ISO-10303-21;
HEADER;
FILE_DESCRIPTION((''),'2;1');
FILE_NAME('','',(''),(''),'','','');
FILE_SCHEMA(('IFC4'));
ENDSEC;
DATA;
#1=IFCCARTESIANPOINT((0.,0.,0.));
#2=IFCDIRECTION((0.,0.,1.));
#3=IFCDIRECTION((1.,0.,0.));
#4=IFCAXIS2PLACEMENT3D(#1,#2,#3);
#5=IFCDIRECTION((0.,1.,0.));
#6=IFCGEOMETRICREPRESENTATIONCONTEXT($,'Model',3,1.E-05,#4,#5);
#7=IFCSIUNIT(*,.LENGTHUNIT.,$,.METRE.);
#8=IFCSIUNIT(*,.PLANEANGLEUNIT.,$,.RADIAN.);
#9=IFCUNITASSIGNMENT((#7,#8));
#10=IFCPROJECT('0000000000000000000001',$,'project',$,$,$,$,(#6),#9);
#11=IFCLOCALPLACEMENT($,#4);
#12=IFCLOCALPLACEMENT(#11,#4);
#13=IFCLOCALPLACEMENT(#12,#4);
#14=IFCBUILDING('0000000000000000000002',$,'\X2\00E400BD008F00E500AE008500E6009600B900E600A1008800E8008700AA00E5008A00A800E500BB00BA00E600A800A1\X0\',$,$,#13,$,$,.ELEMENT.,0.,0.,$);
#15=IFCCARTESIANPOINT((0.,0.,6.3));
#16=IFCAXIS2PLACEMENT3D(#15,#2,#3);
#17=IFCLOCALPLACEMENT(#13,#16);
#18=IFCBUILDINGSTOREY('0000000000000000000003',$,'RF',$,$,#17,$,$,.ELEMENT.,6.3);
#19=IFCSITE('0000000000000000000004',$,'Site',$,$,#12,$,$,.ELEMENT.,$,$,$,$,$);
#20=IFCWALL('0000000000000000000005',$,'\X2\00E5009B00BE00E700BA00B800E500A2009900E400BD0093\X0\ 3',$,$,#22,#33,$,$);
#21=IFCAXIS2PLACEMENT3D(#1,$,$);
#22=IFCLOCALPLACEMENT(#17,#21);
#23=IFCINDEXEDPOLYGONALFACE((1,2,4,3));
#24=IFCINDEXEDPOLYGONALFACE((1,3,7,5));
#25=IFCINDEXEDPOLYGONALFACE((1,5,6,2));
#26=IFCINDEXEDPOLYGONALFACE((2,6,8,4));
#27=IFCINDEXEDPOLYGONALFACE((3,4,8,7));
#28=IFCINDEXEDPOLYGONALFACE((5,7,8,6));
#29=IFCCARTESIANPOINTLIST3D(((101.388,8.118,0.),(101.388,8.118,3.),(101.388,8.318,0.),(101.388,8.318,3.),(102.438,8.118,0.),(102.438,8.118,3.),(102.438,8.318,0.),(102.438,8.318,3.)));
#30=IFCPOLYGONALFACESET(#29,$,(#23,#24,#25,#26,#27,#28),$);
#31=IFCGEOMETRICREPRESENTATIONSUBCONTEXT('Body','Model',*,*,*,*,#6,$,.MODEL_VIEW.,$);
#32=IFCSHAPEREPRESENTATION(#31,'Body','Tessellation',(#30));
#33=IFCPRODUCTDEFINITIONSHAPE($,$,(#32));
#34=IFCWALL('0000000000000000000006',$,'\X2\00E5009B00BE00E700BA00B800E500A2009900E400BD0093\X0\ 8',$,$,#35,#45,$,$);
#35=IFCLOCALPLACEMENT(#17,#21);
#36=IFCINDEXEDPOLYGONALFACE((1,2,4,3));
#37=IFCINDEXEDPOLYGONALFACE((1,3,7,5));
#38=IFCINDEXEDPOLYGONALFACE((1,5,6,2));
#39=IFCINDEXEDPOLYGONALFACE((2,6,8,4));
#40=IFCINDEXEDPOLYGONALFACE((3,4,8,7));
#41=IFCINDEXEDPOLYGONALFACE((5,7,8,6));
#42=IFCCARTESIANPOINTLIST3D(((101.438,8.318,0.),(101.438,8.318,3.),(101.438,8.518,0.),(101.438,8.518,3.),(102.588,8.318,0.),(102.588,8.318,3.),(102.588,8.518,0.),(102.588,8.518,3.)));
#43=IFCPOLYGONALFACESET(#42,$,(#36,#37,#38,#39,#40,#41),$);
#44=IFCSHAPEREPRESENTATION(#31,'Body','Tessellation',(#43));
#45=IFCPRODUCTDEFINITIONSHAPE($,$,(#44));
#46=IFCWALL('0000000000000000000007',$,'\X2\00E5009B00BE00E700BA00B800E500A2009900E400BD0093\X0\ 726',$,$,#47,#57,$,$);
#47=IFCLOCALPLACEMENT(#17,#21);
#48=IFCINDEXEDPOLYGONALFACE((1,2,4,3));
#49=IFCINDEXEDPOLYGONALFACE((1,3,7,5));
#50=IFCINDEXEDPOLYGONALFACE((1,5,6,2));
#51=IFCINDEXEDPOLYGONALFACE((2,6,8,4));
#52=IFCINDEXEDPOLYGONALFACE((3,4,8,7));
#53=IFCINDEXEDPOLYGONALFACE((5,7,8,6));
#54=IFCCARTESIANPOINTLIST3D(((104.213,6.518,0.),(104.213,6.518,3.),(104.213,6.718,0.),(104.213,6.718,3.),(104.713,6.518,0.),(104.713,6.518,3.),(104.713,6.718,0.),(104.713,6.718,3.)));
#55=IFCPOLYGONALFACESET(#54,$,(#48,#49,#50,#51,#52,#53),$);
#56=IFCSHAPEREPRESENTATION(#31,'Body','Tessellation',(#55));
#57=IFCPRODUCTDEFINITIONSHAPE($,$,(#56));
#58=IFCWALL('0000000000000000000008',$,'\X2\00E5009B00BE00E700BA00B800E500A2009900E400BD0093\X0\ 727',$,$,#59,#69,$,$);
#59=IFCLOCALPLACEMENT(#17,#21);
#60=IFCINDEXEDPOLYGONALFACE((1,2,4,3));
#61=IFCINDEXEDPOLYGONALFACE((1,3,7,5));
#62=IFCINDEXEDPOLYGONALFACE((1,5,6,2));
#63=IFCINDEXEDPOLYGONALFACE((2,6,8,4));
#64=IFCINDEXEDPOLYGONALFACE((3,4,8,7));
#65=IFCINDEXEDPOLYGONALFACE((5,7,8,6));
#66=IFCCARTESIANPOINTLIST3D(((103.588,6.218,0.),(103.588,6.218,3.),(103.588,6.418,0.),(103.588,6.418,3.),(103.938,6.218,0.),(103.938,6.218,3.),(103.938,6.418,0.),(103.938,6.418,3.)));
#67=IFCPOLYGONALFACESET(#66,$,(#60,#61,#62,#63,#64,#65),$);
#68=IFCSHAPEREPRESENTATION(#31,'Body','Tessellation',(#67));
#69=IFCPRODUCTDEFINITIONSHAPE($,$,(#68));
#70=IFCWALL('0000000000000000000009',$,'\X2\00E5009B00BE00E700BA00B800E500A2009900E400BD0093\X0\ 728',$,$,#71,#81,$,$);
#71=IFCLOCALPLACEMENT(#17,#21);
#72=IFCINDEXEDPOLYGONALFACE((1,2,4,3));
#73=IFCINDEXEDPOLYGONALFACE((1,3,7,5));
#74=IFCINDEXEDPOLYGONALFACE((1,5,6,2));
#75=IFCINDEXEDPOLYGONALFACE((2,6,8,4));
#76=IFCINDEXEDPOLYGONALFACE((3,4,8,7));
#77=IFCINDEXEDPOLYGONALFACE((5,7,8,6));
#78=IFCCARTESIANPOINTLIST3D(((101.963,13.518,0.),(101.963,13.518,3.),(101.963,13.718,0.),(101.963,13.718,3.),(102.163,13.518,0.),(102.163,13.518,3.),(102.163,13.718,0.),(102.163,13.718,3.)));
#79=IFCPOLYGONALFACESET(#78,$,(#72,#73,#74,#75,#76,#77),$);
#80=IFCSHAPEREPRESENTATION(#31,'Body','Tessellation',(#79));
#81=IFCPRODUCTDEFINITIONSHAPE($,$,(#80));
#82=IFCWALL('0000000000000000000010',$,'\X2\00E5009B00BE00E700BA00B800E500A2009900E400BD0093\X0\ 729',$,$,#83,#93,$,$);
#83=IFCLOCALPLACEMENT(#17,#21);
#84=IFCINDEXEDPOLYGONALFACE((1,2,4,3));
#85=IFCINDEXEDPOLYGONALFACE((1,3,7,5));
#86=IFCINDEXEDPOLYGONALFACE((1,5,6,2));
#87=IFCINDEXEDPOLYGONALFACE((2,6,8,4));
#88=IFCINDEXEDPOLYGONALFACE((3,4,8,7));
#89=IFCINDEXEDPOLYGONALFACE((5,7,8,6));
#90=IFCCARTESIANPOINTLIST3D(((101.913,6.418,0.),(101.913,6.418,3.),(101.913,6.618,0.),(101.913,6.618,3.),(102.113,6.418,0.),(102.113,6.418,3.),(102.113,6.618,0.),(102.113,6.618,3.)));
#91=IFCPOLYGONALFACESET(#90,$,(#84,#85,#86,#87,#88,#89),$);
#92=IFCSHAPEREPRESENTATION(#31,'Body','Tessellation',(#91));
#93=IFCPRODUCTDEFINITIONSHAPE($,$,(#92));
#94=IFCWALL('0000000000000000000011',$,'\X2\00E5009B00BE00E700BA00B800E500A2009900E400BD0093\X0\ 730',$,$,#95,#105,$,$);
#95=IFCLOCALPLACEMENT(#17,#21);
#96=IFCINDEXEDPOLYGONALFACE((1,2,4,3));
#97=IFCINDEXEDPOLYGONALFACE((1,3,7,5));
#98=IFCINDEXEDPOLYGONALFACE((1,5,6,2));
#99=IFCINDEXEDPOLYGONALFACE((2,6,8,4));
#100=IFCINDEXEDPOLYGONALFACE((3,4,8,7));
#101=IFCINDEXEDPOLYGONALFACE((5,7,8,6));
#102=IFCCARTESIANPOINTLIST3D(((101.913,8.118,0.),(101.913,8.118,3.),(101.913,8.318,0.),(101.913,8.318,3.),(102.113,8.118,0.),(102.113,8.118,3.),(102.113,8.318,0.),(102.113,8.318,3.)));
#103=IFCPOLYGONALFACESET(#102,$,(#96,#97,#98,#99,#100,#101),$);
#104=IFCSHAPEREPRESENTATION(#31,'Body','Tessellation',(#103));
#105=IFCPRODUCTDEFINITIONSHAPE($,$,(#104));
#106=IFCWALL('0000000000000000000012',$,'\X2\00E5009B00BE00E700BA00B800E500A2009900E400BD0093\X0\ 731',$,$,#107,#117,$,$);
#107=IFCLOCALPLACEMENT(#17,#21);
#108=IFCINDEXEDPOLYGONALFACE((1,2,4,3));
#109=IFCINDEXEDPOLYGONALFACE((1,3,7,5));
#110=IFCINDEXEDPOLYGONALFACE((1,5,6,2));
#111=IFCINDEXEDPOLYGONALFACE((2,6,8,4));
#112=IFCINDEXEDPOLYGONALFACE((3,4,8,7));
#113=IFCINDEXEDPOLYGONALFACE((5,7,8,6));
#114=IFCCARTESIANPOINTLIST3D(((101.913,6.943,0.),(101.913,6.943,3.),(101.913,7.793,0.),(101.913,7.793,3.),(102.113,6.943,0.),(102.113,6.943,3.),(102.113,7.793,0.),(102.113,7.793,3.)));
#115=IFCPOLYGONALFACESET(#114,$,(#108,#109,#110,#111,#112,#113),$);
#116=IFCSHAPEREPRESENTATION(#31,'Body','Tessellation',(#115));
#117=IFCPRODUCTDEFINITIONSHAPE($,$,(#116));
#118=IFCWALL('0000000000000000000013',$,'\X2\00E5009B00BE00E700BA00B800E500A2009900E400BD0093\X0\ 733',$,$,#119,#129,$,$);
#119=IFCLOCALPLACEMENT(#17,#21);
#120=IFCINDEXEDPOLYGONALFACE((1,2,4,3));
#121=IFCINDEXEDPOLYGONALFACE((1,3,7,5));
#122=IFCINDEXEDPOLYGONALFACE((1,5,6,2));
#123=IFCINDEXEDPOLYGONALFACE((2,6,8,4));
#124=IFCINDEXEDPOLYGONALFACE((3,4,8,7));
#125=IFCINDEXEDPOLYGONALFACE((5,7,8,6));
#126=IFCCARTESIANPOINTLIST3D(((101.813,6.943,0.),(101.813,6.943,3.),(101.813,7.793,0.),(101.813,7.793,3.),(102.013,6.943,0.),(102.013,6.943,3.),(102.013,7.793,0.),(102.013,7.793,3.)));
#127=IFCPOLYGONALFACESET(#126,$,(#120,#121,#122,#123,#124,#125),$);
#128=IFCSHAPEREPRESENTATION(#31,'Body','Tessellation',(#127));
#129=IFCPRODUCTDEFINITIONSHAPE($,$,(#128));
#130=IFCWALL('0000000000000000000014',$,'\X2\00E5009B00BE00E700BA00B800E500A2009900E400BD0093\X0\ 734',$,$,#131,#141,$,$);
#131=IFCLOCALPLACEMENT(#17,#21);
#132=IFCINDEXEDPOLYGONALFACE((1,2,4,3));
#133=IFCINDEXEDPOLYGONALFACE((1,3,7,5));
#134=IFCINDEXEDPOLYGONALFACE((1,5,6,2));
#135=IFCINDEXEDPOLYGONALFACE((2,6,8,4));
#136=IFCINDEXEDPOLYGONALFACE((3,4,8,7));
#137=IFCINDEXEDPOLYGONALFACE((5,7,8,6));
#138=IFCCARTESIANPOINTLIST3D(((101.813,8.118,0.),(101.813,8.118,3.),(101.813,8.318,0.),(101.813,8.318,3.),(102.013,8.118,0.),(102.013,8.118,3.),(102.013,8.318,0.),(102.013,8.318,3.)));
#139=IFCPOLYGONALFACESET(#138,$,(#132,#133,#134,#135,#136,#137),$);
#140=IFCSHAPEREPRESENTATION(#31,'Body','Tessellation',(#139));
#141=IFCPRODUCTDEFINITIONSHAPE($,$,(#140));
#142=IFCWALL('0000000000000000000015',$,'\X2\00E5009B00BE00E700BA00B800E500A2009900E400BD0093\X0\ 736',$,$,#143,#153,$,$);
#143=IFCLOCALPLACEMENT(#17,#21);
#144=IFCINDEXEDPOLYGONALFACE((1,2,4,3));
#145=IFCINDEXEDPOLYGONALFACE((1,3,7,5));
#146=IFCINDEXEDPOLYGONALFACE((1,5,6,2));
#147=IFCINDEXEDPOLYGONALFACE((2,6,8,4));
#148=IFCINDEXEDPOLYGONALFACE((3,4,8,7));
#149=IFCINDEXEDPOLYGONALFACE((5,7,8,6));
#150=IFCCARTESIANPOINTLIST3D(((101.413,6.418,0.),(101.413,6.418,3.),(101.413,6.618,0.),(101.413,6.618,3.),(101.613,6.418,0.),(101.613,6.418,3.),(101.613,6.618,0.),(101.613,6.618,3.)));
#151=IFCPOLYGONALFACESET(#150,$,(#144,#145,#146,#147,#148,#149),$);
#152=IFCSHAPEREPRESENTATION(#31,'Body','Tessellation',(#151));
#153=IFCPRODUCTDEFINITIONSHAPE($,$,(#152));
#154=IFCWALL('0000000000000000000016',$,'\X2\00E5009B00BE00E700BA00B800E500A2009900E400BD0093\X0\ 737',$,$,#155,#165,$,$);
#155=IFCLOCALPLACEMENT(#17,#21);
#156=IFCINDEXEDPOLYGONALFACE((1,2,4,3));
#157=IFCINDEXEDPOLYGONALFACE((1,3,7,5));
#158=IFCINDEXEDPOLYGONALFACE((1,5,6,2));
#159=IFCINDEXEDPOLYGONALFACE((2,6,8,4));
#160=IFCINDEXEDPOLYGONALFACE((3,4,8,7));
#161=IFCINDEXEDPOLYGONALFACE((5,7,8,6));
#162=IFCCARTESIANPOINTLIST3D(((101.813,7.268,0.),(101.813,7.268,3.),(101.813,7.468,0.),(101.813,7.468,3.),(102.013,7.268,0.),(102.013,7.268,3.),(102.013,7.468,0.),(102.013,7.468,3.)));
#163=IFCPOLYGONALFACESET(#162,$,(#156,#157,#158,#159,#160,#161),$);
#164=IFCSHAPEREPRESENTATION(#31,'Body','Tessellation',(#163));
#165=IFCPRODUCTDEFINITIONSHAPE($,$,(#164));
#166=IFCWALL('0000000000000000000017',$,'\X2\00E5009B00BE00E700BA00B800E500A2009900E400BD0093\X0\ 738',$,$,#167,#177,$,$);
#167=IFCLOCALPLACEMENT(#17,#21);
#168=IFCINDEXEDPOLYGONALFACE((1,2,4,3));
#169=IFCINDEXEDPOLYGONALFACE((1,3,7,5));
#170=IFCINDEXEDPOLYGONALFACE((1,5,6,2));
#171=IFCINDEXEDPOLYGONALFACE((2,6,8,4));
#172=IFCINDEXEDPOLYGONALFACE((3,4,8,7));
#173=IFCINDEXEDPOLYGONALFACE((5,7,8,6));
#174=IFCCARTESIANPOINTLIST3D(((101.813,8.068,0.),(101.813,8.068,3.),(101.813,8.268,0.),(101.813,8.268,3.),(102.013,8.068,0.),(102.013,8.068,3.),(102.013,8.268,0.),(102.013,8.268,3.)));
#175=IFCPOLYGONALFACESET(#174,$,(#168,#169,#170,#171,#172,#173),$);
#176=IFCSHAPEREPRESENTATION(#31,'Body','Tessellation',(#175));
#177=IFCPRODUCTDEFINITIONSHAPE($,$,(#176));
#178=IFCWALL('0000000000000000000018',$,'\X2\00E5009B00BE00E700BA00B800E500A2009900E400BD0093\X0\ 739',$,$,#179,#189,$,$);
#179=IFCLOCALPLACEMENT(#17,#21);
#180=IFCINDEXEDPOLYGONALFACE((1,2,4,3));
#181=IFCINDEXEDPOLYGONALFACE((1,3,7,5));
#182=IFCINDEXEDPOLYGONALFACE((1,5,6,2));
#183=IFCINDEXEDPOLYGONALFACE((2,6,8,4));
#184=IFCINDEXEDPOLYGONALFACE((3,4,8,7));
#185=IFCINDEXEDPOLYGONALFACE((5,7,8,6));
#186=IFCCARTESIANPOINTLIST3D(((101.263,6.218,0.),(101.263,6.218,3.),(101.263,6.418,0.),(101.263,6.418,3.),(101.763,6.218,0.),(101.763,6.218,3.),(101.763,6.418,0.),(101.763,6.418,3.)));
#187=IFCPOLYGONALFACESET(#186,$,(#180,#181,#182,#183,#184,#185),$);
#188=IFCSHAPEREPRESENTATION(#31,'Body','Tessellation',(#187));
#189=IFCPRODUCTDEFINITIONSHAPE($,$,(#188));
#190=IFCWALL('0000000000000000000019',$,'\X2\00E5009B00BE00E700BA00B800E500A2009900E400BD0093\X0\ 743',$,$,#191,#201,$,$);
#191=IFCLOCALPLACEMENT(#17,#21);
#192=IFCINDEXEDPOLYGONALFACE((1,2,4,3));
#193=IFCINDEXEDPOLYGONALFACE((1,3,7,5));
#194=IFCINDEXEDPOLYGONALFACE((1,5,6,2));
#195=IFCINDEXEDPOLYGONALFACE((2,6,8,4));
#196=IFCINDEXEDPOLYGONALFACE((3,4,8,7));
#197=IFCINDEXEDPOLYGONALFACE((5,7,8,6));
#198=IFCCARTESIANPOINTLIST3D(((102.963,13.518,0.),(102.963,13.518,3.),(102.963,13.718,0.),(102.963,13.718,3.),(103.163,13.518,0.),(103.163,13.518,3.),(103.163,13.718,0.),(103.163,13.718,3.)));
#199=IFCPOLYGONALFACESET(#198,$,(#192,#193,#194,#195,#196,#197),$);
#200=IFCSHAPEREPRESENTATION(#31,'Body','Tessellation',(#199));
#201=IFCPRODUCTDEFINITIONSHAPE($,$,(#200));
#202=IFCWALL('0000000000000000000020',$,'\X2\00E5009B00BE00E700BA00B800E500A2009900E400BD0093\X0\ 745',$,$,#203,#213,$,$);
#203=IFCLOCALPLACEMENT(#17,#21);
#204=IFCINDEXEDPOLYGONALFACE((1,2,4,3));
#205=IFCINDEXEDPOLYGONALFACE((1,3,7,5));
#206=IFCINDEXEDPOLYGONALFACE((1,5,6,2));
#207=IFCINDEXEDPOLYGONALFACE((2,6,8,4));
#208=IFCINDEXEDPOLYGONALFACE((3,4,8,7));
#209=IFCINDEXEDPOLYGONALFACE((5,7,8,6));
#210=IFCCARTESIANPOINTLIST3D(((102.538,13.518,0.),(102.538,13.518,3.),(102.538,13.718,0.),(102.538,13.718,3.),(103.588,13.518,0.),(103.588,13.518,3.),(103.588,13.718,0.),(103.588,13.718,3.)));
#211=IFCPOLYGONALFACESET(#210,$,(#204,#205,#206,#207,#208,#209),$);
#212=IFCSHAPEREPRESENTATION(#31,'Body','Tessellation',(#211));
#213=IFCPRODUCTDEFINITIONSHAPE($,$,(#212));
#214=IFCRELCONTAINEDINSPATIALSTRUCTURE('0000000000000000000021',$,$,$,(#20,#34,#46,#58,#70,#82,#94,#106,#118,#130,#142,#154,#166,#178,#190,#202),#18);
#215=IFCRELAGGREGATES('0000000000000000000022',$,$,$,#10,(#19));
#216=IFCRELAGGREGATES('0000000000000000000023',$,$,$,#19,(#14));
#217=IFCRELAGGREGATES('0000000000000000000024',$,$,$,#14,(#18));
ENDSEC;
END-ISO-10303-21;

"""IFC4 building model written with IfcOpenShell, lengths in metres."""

from ifc_helpers import new_model, si_unit, direction, frame, frame_2d, origin_with_axes, place, context, subcontext, project, spatial, rectangle, extrude, element, save


model = new_model("IFC4")

# Units and contexts
model_context = context("Model", 3, precision=1e-05, world=origin_with_axes(), true_north=direction((0.0, 1.0, 0.0)))
body_context = subcontext(model_context, "Body", "Model", "MODEL_VIEW")
ifc_project = project(units=[si_unit("LENGTHUNIT", "METRE"), si_unit("PLANEANGLEUNIT", "RADIAN")], contexts=[model_context])

# Site, building, storey
placement = place(None, origin_with_axes())
site_placement = place(placement, origin_with_axes())
site = spatial("IfcSite", under=ifc_project, at=site_placement, Name="Site", CompositionType="ELEMENT")
building_placement = place(site_placement, origin_with_axes())
building = spatial("IfcBuilding", under=site, at=building_placement, Name="ä½\u008få®\u0085æ\u0096¹æ¡\u0088è\u0087ªå\u008a¨å»ºæ¨¡", CompositionType="ELEMENT", ElevationOfRefHeight=0.0, ElevationOfTerrain=0.0)
storey_placement = place(building_placement, frame((0.0, 0.0, 6.3), z_axis=(0.0, 0.0, 1.0), x_axis=(1.0, 0.0, 0.0)))
storey = spatial("IfcBuildingStorey", under=building, at=storey_placement, Name="RF", CompositionType="ELEMENT", Elevation=6.3)

# Walls
wall_1_placement = place(storey_placement, frame((101.913, 8.218, 0.0), z_axis=(0.0, 0.0, 1.0), x_axis=(-1.0, 0.0, 0.0)))
element("IfcWall", 1, at=wall_1_placement, inside=storey, Name="å\u009b¾çº¸å¢\u0099ä½\u0093 3", context=body_context, shape_type="SweptSolid", body=[
    extrude(rectangle(XDim=1.05, YDim=0.2, at=frame_2d((0.0, 0.0), x_axis=(1.0, 0.0, 0.0))), frame((0.0, 0.0, 0.0), z_axis=(0.0, 0.0, 1.0)), (0.0, 0.0, 1.0), 3.0),
])
wall_2_placement = place(storey_placement, frame((102.013, 8.418, 0.0), z_axis=(0.0, 0.0, 1.0), x_axis=(-1.0, 0.0, 0.0)))
element("IfcWall", 2, at=wall_2_placement, inside=storey, Name="å\u009b¾çº¸å¢\u0099ä½\u0093 8", context=body_context, shape_type="SweptSolid", body=[
    extrude(rectangle(XDim=1.15, YDim=0.2, at=frame_2d((0.0, 0.0), x_axis=(1.0, 0.0, 0.0))), frame((0.0, 0.0, 0.0), z_axis=(0.0, 0.0, 1.0)), (0.0, 0.0, 1.0), 3.0),
])
wall_3_placement = place(storey_placement, frame((104.463, 6.618, 0.0), z_axis=(0.0, 0.0, 1.0), x_axis=(1.0, 0.0, 0.0)))
element("IfcWall", 3, at=wall_3_placement, inside=storey, Name="å\u009b¾çº¸å¢\u0099ä½\u0093 726", context=body_context, shape_type="SweptSolid", body=[
    extrude(rectangle(XDim=0.5, YDim=0.2, at=frame_2d((0.0, 0.0), x_axis=(1.0, 0.0, 0.0))), frame((0.0, 0.0, 0.0), z_axis=(0.0, 0.0, 1.0)), (0.0, 0.0, 1.0), 3.0),
])
wall_4_placement = place(storey_placement, frame((103.763, 6.318, 0.0), z_axis=(0.0, 0.0, 1.0), x_axis=(1.0, 0.0, 0.0)))
element("IfcWall", 4, at=wall_4_placement, inside=storey, Name="å\u009b¾çº¸å¢\u0099ä½\u0093 727", context=body_context, shape_type="SweptSolid", body=[
    extrude(rectangle(XDim=0.35, YDim=0.2, at=frame_2d((0.0, 0.0), x_axis=(1.0, 0.0, 0.0))), frame((0.0, 0.0, 0.0), z_axis=(0.0, 0.0, 1.0)), (0.0, 0.0, 1.0), 3.0),
])
for number, where, z_axis, x_axis, name in (
    (5, (102.063, 13.618, 0.0), (0.0, 0.0, 1.0), (0.0, 1.0, 0.0), "å\u009b¾çº¸å¢\u0099ä½\u0093 728"),
    (6, (102.013, 6.518, 0.0), (0.0, 0.0, 1.0), (0.0, -1.0, 0.0), "å\u009b¾çº¸å¢\u0099ä½\u0093 729"),
    (7, (102.013, 8.218, 0.0), (0.0, 0.0, 1.0), (0.0, 1.0, 0.0), "å\u009b¾çº¸å¢\u0099ä½\u0093 730"),
):
    element("IfcWall", number, at=place(storey_placement, frame(where, z_axis=z_axis, x_axis=x_axis)), inside=storey, Name=name, context=body_context, shape_type="SweptSolid", body=[
        extrude(rectangle(XDim=0.2, YDim=0.2, at=frame_2d((0.0, 0.0), x_axis=(1.0, 0.0, 0.0))), frame((0.0, 0.0, 0.0), z_axis=(0.0, 0.0, 1.0)), (0.0, 0.0, 1.0), 3.0),
    ])
wall_5_placement = place(storey_placement, frame((102.013, 7.368, 0.0), z_axis=(0.0, 0.0, 1.0), x_axis=(0.0, -1.0, 0.0)))
element("IfcWall", 8, at=wall_5_placement, inside=storey, Name="å\u009b¾çº¸å¢\u0099ä½\u0093 731", context=body_context, shape_type="SweptSolid", body=[
    extrude(rectangle(XDim=0.85, YDim=0.2, at=frame_2d((0.0, 0.0), x_axis=(1.0, 0.0, 0.0))), frame((0.0, 0.0, 0.0), z_axis=(0.0, 0.0, 1.0)), (0.0, 0.0, 1.0), 3.0),
])
wall_6_placement = place(storey_placement, frame((101.913, 7.368, 0.0), z_axis=(0.0, 0.0, 1.0), x_axis=(0.0, -1.0, 0.0)))
element("IfcWall", 9, at=wall_6_placement, inside=storey, Name="å\u009b¾çº¸å¢\u0099ä½\u0093 733", context=body_context, shape_type="SweptSolid", body=[
    extrude(rectangle(XDim=0.85, YDim=0.2, at=frame_2d((0.0, 0.0), x_axis=(1.0, 0.0, 0.0))), frame((0.0, 0.0, 0.0), z_axis=(0.0, 0.0, 1.0)), (0.0, 0.0, 1.0), 3.0),
])
for number, where, z_axis, x_axis, name in (
    (10, (101.913, 8.218, 0.0), (0.0, 0.0, 1.0), (0.0, -1.0, 0.0), "å\u009b¾çº¸å¢\u0099ä½\u0093 734"),
    (11, (101.513, 6.518, 0.0), (0.0, 0.0, 1.0), (0.0, -1.0, 0.0), "å\u009b¾çº¸å¢\u0099ä½\u0093 736"),
    (12, (101.913, 7.368, 0.0), (0.0, 0.0, 1.0), (1.0, 0.0, 0.0), "å\u009b¾çº¸å¢\u0099ä½\u0093 737"),
    (13, (101.913, 8.168, 0.0), (0.0, 0.0, 1.0), (1.0, 0.0, 0.0), "å\u009b¾çº¸å¢\u0099ä½\u0093 738"),
):
    element("IfcWall", number, at=place(storey_placement, frame(where, z_axis=z_axis, x_axis=x_axis)), inside=storey, Name=name, context=body_context, shape_type="SweptSolid", body=[
        extrude(rectangle(XDim=0.2, YDim=0.2, at=frame_2d((0.0, 0.0), x_axis=(1.0, 0.0, 0.0))), frame((0.0, 0.0, 0.0), z_axis=(0.0, 0.0, 1.0)), (0.0, 0.0, 1.0), 3.0),
    ])
wall_7_placement = place(storey_placement, frame((101.513, 6.318, 0.0), z_axis=(0.0, 0.0, 1.0), x_axis=(1.0, 0.0, 0.0)))
element("IfcWall", 14, at=wall_7_placement, inside=storey, Name="å\u009b¾çº¸å¢\u0099ä½\u0093 739", context=body_context, shape_type="SweptSolid", body=[
    extrude(rectangle(XDim=0.5, YDim=0.2, at=frame_2d((0.0, 0.0), x_axis=(1.0, 0.0, 0.0))), frame((0.0, 0.0, 0.0), z_axis=(0.0, 0.0, 1.0)), (0.0, 0.0, 1.0), 3.0),
])
wall_8_placement = place(storey_placement, frame((103.063, 13.618, 0.0), z_axis=(0.0, 0.0, 1.0), x_axis=(0.0, 1.0, 0.0)))
element("IfcWall", 15, at=wall_8_placement, inside=storey, Name="å\u009b¾çº¸å¢\u0099ä½\u0093 743", context=body_context, shape_type="SweptSolid", body=[
    extrude(rectangle(XDim=0.2, YDim=0.2, at=frame_2d((0.0, 0.0), x_axis=(1.0, 0.0, 0.0))), frame((0.0, 0.0, 0.0), z_axis=(0.0, 0.0, 1.0)), (0.0, 0.0, 1.0), 3.0),
])
wall_9_placement = place(storey_placement, frame((103.063, 13.618, 0.0), z_axis=(0.0, 0.0, 1.0), x_axis=(1.0, 0.0, 0.0)))
element("IfcWall", 16, at=wall_9_placement, inside=storey, Name="å\u009b¾çº¸å¢\u0099ä½\u0093 745", context=body_context, shape_type="SweptSolid", body=[
    extrude(rectangle(XDim=1.05, YDim=0.2, at=frame_2d((0.0, 0.0), x_axis=(1.0, 0.0, 0.0))), frame((0.0, 0.0, 0.0), z_axis=(0.0, 0.0, 1.0)), (0.0, 0.0, 1.0), 3.0),
])

save(model, "model.ifc")
